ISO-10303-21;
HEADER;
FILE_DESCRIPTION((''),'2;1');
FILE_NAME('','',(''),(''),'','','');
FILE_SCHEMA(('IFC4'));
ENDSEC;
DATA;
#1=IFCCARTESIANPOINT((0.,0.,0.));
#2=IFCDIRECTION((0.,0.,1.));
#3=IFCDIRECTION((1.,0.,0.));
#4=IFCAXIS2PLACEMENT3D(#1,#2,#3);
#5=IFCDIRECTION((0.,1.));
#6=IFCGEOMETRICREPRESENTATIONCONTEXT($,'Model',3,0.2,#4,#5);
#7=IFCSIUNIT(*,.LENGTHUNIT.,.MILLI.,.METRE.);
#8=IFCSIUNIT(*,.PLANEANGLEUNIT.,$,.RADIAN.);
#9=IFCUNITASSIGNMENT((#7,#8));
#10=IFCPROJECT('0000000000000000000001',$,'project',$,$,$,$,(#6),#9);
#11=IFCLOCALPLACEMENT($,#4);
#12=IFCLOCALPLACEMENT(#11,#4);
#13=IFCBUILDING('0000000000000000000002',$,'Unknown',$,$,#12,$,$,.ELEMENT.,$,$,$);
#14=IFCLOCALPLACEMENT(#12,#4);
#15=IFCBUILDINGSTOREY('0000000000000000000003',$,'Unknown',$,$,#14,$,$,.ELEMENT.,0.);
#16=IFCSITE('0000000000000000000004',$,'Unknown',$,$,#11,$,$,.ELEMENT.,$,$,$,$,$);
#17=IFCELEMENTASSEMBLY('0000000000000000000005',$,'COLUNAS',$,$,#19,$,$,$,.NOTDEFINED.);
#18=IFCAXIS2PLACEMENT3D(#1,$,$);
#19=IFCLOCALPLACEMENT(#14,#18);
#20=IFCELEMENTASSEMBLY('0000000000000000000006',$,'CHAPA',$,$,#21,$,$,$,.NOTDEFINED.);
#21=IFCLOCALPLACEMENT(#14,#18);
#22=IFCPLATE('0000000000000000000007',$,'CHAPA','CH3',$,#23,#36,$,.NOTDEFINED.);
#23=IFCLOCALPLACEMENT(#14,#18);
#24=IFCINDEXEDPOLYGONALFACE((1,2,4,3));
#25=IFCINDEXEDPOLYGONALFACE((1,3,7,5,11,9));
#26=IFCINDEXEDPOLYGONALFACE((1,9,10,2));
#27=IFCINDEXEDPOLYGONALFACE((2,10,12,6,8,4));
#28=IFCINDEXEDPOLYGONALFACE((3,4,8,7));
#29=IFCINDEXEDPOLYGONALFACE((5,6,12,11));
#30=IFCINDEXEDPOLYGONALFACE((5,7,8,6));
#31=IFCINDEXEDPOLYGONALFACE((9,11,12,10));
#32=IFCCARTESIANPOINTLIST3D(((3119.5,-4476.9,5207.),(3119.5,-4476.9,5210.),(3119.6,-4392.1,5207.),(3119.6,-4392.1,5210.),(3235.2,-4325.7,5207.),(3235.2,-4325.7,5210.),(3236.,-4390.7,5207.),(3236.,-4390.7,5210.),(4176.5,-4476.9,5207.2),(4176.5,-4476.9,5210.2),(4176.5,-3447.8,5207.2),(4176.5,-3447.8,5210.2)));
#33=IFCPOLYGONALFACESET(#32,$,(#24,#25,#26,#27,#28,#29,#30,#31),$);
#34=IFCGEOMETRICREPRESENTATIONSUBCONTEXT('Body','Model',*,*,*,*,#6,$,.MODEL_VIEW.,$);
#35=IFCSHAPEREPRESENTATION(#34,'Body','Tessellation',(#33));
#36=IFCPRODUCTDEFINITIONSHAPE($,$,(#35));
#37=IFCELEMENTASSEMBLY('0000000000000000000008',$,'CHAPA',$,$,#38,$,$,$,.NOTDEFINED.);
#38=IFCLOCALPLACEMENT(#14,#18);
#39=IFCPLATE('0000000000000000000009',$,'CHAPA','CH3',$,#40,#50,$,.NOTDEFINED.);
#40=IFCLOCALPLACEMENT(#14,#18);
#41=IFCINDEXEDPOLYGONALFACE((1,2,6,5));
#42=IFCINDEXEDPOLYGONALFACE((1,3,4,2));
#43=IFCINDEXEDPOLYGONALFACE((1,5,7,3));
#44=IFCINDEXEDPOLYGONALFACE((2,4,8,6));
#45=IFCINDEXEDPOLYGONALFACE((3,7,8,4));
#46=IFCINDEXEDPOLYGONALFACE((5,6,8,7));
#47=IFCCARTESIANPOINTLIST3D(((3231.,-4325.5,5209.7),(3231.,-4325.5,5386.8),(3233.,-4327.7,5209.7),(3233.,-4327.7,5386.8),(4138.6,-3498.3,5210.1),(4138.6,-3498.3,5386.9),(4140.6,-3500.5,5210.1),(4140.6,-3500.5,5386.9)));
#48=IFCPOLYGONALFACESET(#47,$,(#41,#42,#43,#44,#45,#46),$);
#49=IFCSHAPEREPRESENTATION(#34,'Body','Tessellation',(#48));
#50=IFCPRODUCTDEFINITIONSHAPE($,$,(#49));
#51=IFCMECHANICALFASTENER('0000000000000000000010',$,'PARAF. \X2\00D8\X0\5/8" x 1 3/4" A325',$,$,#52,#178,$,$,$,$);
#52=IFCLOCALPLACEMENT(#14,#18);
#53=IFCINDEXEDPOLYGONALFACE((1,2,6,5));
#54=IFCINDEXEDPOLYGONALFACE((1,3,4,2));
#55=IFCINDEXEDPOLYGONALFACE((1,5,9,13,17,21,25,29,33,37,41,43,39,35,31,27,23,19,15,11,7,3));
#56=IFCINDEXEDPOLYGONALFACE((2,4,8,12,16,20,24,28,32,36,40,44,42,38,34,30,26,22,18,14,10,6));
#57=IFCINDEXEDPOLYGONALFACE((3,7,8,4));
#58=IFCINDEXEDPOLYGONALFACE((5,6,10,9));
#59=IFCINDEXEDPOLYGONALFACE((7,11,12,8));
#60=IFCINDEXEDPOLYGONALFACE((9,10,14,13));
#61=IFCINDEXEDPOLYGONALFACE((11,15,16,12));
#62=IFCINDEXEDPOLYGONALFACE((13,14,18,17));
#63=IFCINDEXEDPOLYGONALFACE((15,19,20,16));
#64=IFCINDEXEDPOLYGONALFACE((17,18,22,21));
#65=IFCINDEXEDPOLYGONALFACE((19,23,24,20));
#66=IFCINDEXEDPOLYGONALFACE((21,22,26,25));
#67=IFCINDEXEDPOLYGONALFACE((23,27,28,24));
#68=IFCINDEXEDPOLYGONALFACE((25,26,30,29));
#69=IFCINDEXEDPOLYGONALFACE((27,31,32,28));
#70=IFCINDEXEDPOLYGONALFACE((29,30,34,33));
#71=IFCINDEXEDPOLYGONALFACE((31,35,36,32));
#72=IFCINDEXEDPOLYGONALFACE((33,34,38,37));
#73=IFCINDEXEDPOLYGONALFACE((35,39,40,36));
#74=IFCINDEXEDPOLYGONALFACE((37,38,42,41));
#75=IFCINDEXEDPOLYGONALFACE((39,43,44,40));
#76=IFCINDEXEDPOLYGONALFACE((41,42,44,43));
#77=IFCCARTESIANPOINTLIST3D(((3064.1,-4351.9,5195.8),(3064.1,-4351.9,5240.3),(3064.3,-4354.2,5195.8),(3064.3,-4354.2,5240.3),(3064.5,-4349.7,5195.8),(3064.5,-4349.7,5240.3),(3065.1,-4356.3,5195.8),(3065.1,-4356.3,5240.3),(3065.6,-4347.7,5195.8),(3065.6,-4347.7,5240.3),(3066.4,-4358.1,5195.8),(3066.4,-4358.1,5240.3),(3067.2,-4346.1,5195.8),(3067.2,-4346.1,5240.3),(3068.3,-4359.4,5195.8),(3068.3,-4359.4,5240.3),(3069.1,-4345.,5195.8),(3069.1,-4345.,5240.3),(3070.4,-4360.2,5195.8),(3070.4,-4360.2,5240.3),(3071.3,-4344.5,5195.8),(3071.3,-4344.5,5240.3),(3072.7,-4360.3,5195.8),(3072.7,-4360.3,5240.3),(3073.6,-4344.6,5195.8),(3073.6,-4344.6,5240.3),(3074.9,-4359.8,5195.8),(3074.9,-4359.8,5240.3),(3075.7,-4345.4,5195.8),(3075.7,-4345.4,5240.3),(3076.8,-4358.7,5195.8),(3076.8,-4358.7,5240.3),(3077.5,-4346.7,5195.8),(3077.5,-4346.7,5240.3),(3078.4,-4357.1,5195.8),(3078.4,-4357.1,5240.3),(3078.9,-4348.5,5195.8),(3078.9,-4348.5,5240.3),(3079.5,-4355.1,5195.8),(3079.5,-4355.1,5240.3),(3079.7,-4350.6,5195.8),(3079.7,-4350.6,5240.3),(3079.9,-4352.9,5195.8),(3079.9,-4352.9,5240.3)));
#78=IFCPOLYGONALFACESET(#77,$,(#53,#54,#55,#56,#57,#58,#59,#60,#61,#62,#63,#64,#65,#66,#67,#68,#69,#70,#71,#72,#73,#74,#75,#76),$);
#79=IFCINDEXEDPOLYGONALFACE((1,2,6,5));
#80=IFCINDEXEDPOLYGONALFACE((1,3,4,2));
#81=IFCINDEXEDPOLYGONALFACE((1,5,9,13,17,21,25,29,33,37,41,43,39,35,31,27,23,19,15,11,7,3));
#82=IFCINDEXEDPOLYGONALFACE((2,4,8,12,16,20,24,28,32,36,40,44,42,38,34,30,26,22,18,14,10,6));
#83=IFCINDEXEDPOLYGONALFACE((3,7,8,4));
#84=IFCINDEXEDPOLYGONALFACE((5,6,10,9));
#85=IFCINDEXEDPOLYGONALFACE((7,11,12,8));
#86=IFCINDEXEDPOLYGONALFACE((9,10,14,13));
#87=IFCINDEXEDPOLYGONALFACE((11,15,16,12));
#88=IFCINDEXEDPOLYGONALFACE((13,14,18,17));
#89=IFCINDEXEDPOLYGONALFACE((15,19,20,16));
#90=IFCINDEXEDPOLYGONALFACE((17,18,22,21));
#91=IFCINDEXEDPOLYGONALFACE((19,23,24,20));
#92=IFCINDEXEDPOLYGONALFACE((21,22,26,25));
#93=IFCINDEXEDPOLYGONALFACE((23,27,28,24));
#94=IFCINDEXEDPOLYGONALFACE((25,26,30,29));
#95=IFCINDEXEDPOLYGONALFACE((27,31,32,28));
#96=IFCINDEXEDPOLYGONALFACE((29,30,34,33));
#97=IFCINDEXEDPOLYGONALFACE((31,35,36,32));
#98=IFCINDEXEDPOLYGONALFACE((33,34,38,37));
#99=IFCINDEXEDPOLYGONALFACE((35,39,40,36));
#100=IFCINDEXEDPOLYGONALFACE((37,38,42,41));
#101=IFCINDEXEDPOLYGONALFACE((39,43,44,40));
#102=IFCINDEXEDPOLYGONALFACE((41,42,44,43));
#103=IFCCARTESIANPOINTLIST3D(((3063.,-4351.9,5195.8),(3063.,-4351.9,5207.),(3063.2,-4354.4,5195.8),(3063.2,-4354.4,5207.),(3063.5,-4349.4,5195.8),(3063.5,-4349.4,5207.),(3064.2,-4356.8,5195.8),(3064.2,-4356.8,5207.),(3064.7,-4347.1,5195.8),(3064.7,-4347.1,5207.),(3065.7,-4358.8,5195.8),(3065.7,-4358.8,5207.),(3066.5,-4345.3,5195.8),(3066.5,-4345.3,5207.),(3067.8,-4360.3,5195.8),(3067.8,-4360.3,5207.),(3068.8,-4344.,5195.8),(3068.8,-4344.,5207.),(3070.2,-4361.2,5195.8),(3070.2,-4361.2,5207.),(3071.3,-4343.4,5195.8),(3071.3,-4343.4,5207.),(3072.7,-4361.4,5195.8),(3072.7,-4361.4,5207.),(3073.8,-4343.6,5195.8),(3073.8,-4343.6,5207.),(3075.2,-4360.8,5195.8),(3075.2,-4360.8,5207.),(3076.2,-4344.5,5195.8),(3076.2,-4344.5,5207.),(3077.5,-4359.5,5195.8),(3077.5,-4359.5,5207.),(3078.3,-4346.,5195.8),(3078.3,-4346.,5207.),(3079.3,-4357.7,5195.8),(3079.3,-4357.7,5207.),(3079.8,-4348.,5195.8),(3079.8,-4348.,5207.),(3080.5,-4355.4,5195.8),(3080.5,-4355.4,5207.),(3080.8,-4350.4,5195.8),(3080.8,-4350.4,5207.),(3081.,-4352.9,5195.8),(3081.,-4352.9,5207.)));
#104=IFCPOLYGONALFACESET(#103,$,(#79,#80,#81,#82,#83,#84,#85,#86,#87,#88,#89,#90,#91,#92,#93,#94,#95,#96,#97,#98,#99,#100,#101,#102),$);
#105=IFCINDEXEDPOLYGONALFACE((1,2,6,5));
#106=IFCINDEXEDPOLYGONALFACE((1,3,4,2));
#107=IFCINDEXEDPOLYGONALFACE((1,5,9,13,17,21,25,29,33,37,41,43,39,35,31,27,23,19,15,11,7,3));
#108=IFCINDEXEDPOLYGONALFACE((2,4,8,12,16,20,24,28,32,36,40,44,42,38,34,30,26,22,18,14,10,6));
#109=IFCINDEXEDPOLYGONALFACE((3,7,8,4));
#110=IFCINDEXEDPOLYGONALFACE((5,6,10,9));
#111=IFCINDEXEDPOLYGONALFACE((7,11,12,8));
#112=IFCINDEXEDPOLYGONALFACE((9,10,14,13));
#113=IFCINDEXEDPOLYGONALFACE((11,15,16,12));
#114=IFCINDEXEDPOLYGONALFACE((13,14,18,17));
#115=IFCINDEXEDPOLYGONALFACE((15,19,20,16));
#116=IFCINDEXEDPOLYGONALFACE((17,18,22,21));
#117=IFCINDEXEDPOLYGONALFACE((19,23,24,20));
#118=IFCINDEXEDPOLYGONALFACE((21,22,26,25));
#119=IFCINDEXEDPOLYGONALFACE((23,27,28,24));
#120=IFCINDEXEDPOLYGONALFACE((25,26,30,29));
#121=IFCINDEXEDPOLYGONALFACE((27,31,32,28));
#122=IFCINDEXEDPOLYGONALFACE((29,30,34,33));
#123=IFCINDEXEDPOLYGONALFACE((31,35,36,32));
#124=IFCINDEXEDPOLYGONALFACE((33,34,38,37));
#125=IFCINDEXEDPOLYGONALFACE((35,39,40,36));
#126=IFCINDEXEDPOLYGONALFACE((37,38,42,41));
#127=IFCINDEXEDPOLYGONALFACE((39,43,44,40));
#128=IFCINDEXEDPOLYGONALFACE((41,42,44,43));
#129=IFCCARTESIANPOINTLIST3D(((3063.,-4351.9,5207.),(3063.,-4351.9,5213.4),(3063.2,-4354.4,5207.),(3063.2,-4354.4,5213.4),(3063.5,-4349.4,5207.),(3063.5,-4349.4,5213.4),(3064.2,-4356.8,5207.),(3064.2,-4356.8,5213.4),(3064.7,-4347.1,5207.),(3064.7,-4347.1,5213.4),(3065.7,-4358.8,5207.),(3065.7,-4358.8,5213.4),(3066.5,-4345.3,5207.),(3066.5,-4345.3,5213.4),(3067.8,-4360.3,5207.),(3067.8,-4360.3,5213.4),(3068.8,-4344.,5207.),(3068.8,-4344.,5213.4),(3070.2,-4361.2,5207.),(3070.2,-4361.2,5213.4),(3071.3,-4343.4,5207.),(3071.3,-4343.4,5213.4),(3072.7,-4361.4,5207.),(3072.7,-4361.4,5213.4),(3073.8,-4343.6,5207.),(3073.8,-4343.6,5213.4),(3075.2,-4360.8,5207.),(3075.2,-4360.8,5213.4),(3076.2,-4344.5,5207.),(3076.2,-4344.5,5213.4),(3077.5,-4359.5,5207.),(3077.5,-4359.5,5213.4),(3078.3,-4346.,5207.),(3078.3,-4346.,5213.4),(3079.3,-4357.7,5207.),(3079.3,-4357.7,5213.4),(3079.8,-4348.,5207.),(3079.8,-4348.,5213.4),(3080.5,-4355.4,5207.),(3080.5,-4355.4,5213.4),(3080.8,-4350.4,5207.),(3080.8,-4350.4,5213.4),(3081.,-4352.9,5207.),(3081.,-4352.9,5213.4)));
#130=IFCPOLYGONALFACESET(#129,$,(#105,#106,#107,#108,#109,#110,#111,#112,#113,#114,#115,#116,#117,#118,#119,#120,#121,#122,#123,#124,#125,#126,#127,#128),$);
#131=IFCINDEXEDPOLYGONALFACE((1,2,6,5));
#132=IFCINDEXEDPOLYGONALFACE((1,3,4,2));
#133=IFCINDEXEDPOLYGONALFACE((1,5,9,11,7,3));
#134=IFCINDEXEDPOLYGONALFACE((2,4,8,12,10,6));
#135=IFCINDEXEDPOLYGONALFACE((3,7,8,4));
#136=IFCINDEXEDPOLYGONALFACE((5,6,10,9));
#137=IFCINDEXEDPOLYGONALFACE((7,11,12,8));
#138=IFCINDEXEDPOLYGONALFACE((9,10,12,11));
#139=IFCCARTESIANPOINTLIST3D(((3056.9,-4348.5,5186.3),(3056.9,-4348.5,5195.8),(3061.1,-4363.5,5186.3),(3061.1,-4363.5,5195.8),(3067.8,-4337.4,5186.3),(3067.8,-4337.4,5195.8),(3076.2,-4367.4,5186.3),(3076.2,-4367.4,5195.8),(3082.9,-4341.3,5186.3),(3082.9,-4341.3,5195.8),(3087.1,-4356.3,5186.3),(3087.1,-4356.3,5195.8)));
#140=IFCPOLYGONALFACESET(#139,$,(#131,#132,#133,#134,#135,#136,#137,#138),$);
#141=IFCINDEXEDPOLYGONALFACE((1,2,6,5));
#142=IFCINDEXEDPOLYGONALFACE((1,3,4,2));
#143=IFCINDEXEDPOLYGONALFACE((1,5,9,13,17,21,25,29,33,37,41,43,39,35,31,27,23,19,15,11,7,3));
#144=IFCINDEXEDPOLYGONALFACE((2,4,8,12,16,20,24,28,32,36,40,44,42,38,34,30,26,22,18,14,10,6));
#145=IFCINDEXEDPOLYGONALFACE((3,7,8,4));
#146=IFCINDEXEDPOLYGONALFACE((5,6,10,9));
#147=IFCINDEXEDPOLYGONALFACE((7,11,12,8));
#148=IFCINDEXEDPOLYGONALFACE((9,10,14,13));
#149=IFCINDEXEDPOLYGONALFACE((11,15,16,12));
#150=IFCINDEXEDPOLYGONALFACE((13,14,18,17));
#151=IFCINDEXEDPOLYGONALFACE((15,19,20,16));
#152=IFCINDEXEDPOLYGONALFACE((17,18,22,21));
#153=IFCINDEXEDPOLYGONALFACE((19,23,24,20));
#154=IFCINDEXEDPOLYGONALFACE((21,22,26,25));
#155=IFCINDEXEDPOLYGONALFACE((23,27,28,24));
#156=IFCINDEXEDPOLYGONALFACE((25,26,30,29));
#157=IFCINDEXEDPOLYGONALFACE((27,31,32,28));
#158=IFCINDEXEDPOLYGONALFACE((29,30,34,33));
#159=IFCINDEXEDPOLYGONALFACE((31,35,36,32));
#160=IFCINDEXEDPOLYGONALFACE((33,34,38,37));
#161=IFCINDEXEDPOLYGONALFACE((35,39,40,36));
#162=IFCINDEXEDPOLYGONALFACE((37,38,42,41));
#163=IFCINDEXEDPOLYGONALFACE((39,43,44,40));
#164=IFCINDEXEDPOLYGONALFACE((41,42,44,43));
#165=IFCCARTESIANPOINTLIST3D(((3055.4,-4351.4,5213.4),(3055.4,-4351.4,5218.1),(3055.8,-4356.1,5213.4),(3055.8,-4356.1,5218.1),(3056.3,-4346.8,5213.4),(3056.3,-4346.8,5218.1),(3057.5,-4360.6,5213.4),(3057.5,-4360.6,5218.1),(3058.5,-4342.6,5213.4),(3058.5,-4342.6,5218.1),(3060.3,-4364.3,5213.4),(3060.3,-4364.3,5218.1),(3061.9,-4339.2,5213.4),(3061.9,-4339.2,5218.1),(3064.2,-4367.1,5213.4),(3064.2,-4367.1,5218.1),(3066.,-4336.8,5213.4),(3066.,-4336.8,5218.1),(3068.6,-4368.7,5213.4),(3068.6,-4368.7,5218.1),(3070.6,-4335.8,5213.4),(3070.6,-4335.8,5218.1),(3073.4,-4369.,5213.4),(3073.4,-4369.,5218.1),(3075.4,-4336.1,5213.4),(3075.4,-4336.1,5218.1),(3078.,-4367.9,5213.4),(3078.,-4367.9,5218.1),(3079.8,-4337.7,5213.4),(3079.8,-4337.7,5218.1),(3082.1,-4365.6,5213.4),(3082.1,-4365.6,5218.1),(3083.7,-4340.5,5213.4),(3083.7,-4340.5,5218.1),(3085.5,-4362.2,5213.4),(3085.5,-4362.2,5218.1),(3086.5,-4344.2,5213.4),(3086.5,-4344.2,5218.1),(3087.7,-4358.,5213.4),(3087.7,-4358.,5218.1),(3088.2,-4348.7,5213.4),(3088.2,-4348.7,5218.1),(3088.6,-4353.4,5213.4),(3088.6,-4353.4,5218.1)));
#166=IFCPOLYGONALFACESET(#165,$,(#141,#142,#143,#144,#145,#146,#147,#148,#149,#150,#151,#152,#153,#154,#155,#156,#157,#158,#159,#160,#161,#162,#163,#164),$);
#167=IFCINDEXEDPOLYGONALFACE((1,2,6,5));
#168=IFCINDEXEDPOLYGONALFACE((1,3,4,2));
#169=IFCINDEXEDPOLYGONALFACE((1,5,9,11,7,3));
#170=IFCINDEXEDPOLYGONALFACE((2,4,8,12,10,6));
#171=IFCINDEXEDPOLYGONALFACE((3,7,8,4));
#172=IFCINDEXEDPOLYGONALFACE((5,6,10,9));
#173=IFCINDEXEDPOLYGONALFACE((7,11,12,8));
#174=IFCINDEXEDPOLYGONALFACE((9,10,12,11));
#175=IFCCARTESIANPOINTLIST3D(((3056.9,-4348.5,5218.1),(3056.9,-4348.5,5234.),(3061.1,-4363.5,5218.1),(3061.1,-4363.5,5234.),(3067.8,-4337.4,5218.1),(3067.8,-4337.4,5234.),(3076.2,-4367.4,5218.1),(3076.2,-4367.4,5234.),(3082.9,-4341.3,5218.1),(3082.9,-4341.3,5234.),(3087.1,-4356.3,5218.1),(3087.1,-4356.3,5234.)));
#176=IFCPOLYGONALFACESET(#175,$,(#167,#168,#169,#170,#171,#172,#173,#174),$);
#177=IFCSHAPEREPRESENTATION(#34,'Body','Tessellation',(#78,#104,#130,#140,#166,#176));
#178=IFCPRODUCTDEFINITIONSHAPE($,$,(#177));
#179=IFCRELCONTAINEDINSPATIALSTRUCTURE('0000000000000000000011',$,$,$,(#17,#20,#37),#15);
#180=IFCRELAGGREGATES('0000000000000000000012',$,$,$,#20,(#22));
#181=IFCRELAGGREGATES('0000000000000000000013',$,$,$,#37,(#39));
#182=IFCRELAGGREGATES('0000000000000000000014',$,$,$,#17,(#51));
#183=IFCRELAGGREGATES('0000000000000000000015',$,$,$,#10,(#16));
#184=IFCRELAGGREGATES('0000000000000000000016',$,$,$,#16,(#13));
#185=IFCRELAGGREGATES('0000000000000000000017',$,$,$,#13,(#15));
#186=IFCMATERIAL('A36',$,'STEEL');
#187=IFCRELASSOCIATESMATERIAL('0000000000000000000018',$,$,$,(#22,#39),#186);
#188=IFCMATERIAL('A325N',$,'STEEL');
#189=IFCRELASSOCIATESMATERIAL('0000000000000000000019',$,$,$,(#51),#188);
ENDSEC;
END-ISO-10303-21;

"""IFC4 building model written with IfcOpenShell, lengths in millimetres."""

from ifc_helpers import new_model, si_unit, direction, frame, origin_with_axes, place, context, subcontext, project, spatial, line, arc, indexed_curve, outline, extrude, source, transform, mapped, material, element, aggregate, save


model = new_model("IFC4")

# Units and contexts
model_context = context("Model", 3, precision=0.2, world=origin_with_axes(), true_north=direction((0.0, 1.0)))
body_context = subcontext(model_context, "Body", "Model", "MODEL_VIEW")
ifc_project = project(units=[si_unit("LENGTHUNIT", "METRE", prefix="MILLI"), si_unit("PLANEANGLEUNIT", "RADIAN")], contexts=[model_context])

# Site, building, storey
site_placement = place(None, origin_with_axes())
site = spatial("IfcSite", under=ifc_project, at=site_placement, Name="Unknown", CompositionType="ELEMENT")
building_placement = place(site_placement, origin_with_axes())
building = spatial("IfcBuilding", under=site, at=building_placement, Name="Unknown", CompositionType="ELEMENT")
storey_placement = place(building_placement, origin_with_axes())
storey = spatial("IfcBuildingStorey", under=building, at=storey_placement, Name="Unknown", CompositionType="ELEMENT", Elevation=0.0)

# Element assembly
assembly_1_placement = place(storey_placement, frame((3148.0, -5579.5, 4124.5), z_axis=(-1.0, 0.0, 0.0), x_axis=(0.0, 0.0, 1.0)))
assembly_1 = element("IfcElementAssembly", 1, at=assembly_1_placement, inside=storey, Name="COLUNAS", PredefinedType="NOTDEFINED")
ifc_material_1 = material(Name="A36", Category="STEEL")

# Element assembly, plate
assembly_2_placement = place(storey_placement, frame((3235.2, -4325.7, 5208.5), z_axis=(-0.000243, 0.0, 1.0), x_axis=(0.011564, -0.999933, 0.000003)))
assembly_2 = element("IfcElementAssembly", 2, at=assembly_2_placement, inside=storey, Name="CHAPA", PredefinedType="NOTDEFINED")
plate_1_placement = place(assembly_2_placement, origin_with_axes())
plate_1 = element("IfcPlate", 3, at=plate_1_placement, material=ifc_material_1, Name="CHAPA", Description="CH3", PredefinedType="NOTDEFINED", context=body_context, shape_type="SolidModel", body=[
    extrude(outline(indexed_curve([(0.0, 0.0), (65.0, 0.0), (65.0, -116.4), (149.9, -117.5), (162.1, 939.4), (-866.9, 951.4)], segments=[line(1, 2, 3, 4, 5, 6, 1)])), frame((0.0, 0.0, 1.5), z_axis=(0.0, 0.0, 1.0), x_axis=(1.0, 0.0, 0.0)), (0.0, 0.0, -1.0), 3.0),
])
aggregate(assembly_2, [plate_1])

# Element assembly, plate
assembly_3_placement = place(storey_placement, frame((3110.8, -4325.4, 5388.3), z_axis=(0.0, -0.000186, 1.0), x_axis=(1.0, -0.000424, 0.0)))
assembly_3 = element("IfcElementAssembly", 4, at=assembly_3_placement, inside=storey, Name="CHAPA", PredefinedType="NOTDEFINED")
plate_2_placement = place(assembly_3_placement, frame((121.2, -1.1, -1.5), z_axis=(-0.673934, 0.738792, -0.000096), x_axis=(0.738792, 0.673934, 0.000004)))
plate_2 = element("IfcPlate", 5, at=plate_2_placement, material=ifc_material_1, Name="CHAPA", Description="CH3", PredefinedType="NOTDEFINED", context=body_context, shape_type="SolidModel", body=[
    extrude(outline(indexed_curve([(0.0, 0.0), (1228.0, 0.0), (1228.0, 176.9), (0.0, 177.0)], segments=[line(1, 2, 3, 4, 1)])), frame((0.0, 0.0, 1.5), z_axis=(0.0, 0.0, 1.0), x_axis=(1.0, 0.0, 0.0)), (0.0, 0.0, -1.0), 3.0),
])
aggregate(assembly_3, [plate_2])

# Mechanical fastener
ifc_material_2 = material(Name="A325N", Category="STEEL")
shared_shape_1 = source(origin_with_axes(), body_context, "Body", "SweptSolid", [
    extrude(outline(indexed_curve([(7.9, 0.0), (0.0, 7.9), (-7.9, 0.0), (0.0, -7.9)], segments=[arc(1, 2, 3), arc(3, 4, 1)])), frame((0.0, 0.0, 17.5), z_axis=(0.0, 0.0, -1.0), x_axis=(0.0, 1.0, 0.0)), (0.0, 0.0, 1.0), 44.5),
    extrude(outline(indexed_curve([(9.0, 0.0), (0.0, 9.0), (-9.0, 0.0), (0.0, -9.0)], segments=[arc(1, 2, 3), arc(3, 4, 1)])), frame((0.0, 0.0, 17.5), z_axis=(0.0, 0.0, -1.0), x_axis=(0.0, 1.0, 0.0)), (0.0, 0.0, 1.0), 11.2),
    extrude(outline(indexed_curve([(9.0, 0.0), (0.0, 9.0), (-9.0, 0.0), (0.0, -9.0)], segments=[arc(1, 2, 3), arc(3, 4, 1)])), frame((0.0, 0.0, 6.3), z_axis=(0.0, 0.0, -1.0), x_axis=(0.0, 1.0, 0.0)), (0.0, 0.0, 1.0), 6.4),
    extrude(outline(indexed_curve([(15.6, 0.0), (7.8, 13.5), (-7.8, 13.5), (-15.6, 0.0), (-7.8, -13.5), (7.8, -13.5)], segments=[line(1, 2, 3, 4, 5, 6, 1)])), frame((0.0, 0.0, 27.0), z_axis=(0.0, 0.0, -1.0), x_axis=(0.0, 1.0, 0.0)), (0.0, 0.0, 1.0), 9.5),
    extrude(outline(indexed_curve([(16.7, 0.0), (0.0, 16.7), (-16.7, 0.0), (0.0, -16.7)], segments=[arc(1, 2, 3), arc(3, 4, 1)])), frame((0.0, 0.0, 0.0), z_axis=(0.0, 0.0, -1.0), x_axis=(0.0, 1.0, 0.0)), (0.0, 0.0, 1.0), 4.8),
    extrude(outline(indexed_curve([(15.6, 0.0), (7.8, 13.5), (-7.8, 13.5), (-15.6, 0.0), (-7.8, -13.5), (7.8, -13.5)], segments=[line(1, 2, 3, 4, 5, 6, 1)])), frame((0.0, 0.0, -4.8), z_axis=(0.0, 0.0, -1.0), x_axis=(0.0, 1.0, 0.0)), (0.0, 0.0, 1.0), 15.9),
])
mechanical_fastener_1_placement = place(assembly_1_placement, frame((1088.8, 1227.1, 76.0), z_axis=(-1.0, 0.0, 0.0), x_axis=(0.0, -0.698958, -0.715163)))
mechanical_fastener_1 = element("IfcMechanicalFastener", 6, at=mechanical_fastener_1_placement, material=ifc_material_2, Name="PARAF. Ø5/8\" x 1 3/4\" A325", context=body_context, shape_type="MappedRepresentation", body=[
    mapped(shared_shape_1, transform((0.0, 0.0, 0.0))),
])
aggregate(assembly_1, [mechanical_fastener_1])

save(model, "model.ifc")
